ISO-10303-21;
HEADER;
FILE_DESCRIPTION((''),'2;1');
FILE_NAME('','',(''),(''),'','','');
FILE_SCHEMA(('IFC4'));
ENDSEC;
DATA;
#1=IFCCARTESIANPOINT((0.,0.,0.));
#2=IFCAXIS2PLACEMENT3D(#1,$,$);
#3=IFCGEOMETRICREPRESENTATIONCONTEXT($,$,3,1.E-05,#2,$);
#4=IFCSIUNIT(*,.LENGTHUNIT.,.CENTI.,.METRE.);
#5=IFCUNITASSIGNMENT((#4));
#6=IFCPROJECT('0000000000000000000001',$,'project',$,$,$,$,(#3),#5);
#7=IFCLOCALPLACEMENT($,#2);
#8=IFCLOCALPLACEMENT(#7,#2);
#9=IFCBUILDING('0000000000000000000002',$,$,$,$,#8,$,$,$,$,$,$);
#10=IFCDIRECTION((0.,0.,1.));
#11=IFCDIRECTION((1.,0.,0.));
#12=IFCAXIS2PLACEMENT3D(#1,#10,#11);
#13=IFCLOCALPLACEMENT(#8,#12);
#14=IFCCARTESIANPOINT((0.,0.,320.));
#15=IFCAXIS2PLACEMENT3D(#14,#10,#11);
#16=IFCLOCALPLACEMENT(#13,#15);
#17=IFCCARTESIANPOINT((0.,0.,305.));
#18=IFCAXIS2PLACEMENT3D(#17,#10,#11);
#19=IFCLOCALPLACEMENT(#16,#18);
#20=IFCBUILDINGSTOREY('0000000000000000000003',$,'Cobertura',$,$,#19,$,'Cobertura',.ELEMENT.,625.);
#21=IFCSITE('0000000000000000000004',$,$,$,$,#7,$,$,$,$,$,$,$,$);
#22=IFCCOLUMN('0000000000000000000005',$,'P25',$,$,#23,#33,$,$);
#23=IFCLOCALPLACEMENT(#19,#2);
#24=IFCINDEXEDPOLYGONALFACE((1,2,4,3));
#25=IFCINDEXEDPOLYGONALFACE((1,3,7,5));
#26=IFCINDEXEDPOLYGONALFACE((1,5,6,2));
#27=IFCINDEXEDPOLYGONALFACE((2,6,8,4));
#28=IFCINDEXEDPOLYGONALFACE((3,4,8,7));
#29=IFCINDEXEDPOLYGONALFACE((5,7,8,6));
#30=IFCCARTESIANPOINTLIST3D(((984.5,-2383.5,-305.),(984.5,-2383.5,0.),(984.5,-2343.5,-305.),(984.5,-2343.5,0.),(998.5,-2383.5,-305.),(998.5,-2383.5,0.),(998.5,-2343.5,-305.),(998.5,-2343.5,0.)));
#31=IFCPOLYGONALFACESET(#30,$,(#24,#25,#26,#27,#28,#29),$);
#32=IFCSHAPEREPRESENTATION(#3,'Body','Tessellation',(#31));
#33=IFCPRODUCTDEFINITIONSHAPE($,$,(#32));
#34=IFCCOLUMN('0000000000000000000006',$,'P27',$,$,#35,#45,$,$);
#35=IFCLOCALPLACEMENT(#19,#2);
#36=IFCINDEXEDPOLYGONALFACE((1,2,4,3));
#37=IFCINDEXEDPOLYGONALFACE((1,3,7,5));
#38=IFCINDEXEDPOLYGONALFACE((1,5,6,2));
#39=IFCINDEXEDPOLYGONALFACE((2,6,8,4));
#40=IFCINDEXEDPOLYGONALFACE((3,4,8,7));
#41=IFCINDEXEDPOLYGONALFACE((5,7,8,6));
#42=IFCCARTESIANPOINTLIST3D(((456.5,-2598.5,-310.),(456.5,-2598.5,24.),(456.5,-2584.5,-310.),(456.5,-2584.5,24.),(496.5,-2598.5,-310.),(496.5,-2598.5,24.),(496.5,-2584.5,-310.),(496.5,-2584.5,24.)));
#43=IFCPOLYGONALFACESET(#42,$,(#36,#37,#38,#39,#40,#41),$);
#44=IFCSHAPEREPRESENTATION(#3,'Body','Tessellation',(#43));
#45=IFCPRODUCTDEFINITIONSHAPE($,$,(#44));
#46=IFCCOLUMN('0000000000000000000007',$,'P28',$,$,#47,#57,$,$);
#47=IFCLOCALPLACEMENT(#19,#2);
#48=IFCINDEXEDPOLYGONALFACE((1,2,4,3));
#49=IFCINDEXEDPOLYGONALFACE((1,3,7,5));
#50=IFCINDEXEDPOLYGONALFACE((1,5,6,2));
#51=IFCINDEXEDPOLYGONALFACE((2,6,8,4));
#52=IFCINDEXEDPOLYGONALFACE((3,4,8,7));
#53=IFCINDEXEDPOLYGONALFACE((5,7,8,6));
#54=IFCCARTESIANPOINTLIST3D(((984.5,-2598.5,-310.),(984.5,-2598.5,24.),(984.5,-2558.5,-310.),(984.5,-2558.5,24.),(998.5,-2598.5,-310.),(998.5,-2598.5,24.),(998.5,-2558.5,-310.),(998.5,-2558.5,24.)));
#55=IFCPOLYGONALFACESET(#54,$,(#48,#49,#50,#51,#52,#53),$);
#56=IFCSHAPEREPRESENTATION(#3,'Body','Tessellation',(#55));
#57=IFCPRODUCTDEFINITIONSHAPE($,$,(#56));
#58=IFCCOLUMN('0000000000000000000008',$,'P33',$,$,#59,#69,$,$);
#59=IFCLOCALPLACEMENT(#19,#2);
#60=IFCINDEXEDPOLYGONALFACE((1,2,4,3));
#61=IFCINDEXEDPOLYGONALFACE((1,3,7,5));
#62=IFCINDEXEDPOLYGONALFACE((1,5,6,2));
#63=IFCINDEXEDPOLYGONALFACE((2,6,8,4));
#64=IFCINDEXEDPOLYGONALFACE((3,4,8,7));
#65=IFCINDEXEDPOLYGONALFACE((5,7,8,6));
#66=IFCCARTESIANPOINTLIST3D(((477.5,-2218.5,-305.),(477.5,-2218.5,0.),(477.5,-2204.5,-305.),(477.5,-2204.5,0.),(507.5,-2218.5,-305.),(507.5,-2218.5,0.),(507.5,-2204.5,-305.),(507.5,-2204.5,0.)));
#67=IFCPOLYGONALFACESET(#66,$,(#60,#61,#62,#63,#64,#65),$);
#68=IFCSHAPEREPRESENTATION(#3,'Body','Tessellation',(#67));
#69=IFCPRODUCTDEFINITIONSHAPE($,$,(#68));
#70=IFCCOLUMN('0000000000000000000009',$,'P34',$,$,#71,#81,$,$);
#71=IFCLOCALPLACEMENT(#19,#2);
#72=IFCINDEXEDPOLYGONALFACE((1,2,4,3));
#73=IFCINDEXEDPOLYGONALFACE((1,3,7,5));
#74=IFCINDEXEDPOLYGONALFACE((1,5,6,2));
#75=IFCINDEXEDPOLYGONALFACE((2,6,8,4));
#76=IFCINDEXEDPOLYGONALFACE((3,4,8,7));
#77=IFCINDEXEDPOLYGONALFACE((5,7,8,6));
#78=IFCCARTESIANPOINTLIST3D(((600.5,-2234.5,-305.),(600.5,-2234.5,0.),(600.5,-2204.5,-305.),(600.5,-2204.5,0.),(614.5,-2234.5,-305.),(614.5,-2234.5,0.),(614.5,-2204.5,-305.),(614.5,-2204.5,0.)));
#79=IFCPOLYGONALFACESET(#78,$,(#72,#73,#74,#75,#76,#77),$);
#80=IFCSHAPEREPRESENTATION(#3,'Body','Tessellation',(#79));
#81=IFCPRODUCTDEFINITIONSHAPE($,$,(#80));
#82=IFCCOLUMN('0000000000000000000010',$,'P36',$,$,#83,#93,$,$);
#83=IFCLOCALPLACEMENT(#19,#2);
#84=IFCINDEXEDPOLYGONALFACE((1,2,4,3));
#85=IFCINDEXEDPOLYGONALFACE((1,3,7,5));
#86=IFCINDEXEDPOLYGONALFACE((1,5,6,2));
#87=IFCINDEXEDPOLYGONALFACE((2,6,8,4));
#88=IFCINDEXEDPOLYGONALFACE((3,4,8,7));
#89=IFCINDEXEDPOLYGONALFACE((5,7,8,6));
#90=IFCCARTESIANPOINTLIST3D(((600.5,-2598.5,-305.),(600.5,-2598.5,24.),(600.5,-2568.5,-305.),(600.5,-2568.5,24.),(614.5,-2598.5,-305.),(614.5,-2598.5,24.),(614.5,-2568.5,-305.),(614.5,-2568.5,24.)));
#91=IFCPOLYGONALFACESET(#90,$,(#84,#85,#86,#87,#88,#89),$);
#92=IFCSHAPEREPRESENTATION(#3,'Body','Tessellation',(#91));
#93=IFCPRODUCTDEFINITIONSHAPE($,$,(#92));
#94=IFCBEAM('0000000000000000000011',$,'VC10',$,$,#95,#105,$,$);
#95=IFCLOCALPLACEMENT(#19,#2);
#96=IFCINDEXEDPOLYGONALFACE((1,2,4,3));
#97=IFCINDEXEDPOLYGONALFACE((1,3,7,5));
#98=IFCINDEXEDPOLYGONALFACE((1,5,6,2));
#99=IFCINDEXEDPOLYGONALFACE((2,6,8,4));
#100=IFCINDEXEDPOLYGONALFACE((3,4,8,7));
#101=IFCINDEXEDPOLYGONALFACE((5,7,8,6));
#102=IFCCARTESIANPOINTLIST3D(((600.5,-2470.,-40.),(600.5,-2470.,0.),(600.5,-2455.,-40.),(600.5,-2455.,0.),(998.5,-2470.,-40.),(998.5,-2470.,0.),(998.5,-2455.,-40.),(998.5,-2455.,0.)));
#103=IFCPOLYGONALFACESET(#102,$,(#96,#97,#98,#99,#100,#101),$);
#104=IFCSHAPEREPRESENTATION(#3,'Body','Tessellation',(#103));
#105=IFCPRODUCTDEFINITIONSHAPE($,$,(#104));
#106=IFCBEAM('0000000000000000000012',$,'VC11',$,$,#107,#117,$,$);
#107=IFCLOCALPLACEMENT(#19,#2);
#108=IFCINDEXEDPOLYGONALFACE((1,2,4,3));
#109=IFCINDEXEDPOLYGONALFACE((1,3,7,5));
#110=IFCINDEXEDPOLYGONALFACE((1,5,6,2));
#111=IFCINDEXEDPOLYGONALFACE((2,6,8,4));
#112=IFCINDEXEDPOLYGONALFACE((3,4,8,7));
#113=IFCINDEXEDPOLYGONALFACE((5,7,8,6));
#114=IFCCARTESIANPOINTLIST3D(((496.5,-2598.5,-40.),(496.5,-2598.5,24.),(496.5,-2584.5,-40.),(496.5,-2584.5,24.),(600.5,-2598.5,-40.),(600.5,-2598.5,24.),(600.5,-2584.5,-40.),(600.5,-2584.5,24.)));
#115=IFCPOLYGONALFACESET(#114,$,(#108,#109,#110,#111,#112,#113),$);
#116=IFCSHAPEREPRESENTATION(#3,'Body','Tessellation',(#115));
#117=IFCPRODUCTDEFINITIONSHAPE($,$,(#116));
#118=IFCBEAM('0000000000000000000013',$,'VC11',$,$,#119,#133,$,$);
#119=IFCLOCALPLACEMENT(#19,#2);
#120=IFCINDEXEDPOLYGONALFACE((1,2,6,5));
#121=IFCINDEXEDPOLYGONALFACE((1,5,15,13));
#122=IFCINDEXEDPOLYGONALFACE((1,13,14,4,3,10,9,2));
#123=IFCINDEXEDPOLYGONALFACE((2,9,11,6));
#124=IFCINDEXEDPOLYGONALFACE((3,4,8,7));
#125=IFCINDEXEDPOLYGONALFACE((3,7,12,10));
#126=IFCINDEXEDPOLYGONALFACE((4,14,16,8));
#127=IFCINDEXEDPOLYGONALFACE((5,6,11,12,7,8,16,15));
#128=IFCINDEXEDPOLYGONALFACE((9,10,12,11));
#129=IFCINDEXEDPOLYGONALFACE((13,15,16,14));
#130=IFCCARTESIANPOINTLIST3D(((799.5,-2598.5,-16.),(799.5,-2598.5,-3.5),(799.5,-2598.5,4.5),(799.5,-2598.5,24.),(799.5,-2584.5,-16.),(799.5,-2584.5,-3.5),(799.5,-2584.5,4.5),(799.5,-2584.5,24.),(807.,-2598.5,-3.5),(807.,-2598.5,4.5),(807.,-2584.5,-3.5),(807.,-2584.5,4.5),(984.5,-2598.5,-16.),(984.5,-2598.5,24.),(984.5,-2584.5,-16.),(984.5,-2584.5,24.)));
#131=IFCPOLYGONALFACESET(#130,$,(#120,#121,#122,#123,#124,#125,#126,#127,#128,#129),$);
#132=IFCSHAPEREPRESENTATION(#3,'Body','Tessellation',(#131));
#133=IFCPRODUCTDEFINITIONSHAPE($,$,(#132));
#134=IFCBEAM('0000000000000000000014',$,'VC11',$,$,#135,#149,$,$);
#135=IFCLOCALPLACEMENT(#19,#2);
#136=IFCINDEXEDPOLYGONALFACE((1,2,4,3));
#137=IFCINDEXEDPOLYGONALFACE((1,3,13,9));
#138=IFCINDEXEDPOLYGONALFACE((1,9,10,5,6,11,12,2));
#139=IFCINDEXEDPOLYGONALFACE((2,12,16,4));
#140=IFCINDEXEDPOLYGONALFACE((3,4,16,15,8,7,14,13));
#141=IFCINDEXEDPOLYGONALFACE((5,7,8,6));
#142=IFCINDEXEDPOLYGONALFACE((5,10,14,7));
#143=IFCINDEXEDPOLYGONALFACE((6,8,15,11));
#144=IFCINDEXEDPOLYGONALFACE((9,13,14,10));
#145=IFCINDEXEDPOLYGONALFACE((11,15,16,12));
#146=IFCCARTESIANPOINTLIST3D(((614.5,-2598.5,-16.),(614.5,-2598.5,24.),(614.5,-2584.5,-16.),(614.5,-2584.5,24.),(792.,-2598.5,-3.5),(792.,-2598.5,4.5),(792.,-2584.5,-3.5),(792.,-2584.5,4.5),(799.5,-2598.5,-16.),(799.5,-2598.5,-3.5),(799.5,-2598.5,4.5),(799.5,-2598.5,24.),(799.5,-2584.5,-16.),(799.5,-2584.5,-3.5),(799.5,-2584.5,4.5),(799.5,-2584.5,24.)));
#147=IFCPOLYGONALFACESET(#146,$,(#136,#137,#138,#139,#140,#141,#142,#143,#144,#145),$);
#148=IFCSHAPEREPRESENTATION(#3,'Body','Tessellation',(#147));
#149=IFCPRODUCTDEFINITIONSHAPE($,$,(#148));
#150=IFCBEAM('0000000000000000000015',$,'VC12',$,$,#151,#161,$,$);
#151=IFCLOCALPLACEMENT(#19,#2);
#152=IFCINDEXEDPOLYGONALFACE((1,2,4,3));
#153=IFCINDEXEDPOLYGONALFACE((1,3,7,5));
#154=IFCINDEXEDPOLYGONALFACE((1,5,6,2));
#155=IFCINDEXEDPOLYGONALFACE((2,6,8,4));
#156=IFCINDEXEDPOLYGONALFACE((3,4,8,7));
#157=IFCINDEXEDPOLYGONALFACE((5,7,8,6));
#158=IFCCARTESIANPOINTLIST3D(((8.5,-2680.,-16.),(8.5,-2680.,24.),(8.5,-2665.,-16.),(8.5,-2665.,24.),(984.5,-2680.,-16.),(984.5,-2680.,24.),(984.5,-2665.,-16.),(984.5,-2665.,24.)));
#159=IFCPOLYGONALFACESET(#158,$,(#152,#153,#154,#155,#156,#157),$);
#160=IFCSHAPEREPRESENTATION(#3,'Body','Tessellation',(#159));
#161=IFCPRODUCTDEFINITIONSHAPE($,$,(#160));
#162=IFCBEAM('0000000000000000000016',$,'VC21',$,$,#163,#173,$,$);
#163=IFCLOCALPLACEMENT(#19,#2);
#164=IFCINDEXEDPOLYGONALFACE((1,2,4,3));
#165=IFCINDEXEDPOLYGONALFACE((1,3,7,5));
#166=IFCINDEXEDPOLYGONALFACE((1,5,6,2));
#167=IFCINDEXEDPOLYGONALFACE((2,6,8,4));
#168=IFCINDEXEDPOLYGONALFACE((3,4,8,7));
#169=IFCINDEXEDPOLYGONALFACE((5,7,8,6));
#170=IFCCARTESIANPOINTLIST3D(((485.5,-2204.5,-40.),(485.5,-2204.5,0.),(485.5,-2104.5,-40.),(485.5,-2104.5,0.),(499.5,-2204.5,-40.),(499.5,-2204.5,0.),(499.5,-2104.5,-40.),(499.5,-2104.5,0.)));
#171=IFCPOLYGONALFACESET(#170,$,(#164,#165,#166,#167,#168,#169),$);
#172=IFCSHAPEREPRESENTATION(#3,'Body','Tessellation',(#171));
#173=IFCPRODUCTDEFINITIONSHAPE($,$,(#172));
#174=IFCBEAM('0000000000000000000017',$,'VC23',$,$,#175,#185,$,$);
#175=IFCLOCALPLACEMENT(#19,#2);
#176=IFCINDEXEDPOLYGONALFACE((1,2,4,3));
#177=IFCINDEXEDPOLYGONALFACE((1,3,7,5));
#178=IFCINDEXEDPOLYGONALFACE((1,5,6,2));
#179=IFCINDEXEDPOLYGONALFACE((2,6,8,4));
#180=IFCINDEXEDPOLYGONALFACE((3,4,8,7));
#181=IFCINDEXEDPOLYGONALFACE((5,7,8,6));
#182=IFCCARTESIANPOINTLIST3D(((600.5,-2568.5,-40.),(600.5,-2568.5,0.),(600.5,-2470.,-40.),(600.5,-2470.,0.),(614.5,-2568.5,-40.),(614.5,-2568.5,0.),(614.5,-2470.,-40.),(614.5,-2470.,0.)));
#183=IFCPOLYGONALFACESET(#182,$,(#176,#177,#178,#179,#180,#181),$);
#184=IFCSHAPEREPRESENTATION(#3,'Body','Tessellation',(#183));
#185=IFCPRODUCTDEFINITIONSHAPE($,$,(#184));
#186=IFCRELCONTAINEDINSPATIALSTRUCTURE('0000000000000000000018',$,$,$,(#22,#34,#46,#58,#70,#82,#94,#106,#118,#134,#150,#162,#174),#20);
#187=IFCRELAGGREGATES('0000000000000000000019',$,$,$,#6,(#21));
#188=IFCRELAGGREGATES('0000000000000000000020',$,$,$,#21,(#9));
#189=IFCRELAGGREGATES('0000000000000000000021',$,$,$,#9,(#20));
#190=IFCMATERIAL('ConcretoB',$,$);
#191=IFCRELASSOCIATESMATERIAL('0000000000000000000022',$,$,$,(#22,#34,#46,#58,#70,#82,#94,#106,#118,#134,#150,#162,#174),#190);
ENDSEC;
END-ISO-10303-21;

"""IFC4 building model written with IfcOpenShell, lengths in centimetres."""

from ifc_helpers import new_model, si_unit, frame, origin, origin_with_axes, place, context, project, spatial, polyline, outline, extrude, material, element, save


model = new_model("IFC4")

# Units and contexts
context_of_model = context(None, 3, precision=1e-05, world=origin())
ifc_project = project(units=[si_unit("LENGTHUNIT", "METRE", prefix="CENTI")], contexts=[context_of_model])

# Site, building, storey
site_placement = place(None, origin())
site = spatial("IfcSite", under=ifc_project, at=site_placement)
building_placement = place(site_placement, origin())
building = spatial("IfcBuilding", under=site, at=building_placement)
placement_1 = place(building_placement, origin_with_axes())
placement_2 = place(placement_1, frame((0.0, 0.0, 320.0), z_axis=(0.0, 0.0, 1.0), x_axis=(1.0, 0.0, 0.0)))
storey_placement = place(placement_2, frame((0.0, 0.0, 305.0), z_axis=(0.0, 0.0, 1.0), x_axis=(1.0, 0.0, 0.0)))
storey = spatial("IfcBuildingStorey", under=building, at=storey_placement, Name="Cobertura", LongName="Cobertura", CompositionType="ELEMENT", Elevation=625.0)

# Columns
ifc_material = material(Name="ConcretoB")
column_1_placement = place(storey_placement, frame((991.5, -2363.5, 0.0), z_axis=(0.0, 0.0, 1.0), x_axis=(1.0, 0.0, 0.0)))
element("IfcColumn", 1, at=column_1_placement, inside=storey, material=ifc_material, Name="P25", context=context_of_model, shape_type="SolidModel", body=[
    extrude(outline(polyline([(7.0, 20.0), (-7.0, 20.0), (-7.0, -20.0), (7.0, -20.0), (7.0, 20.0)])), origin_with_axes(), (0.0, 0.0, -1.0), 305.0),
])
column_2_placement = place(storey_placement, frame((476.5, -2591.5, 24.0), z_axis=(0.0, 0.0, 1.0), x_axis=(1.0, 0.0, 0.0)))
element("IfcColumn", 2, at=column_2_placement, inside=storey, material=ifc_material, Name="P27", context=context_of_model, shape_type="SolidModel", body=[
    extrude(outline(polyline([(20.0, -7.0), (20.0, 7.0), (-20.0, 7.0), (-20.0, -7.0), (20.0, -7.0)])), origin_with_axes(), (0.0, 0.0, -1.0), 334.0),
])
column_3_placement = place(storey_placement, frame((991.5, -2578.5, 24.0), z_axis=(0.0, 0.0, 1.0), x_axis=(1.0, 0.0, 0.0)))
element("IfcColumn", 3, at=column_3_placement, inside=storey, material=ifc_material, Name="P28", context=context_of_model, shape_type="SolidModel", body=[
    extrude(outline(polyline([(7.0, 20.0), (-7.0, 20.0), (-7.0, -20.0), (7.0, -20.0), (7.0, 20.0)])), origin_with_axes(), (0.0, 0.0, -1.0), 334.0),
])
column_4_placement = place(storey_placement, frame((492.5, -2211.5, 0.0), z_axis=(0.0, 0.0, 1.0), x_axis=(1.0, 0.0, 0.0)))
element("IfcColumn", 4, at=column_4_placement, inside=storey, material=ifc_material, Name="P33", context=context_of_model, shape_type="SolidModel", body=[
    extrude(outline(polyline([(15.0, -7.0), (15.0, 7.0), (-15.0, 7.0), (-15.0, -7.0), (15.0, -7.0)])), origin_with_axes(), (0.0, 0.0, -1.0), 305.0),
])
column_5_placement = place(storey_placement, frame((607.5, -2219.5, 0.0), z_axis=(0.0, 0.0, 1.0), x_axis=(1.0, 0.0, 0.0)))
element("IfcColumn", 5, at=column_5_placement, inside=storey, material=ifc_material, Name="P34", context=context_of_model, shape_type="SolidModel", body=[
    extrude(outline(polyline([(7.0, 15.0), (-7.0, 15.0), (-7.0, -15.0), (7.0, -15.0), (7.0, 15.0)])), origin_with_axes(), (0.0, 0.0, -1.0), 305.0),
])
column_6_placement = place(storey_placement, frame((607.5, -2583.5, 24.0), z_axis=(0.0, 0.0, 1.0), x_axis=(1.0, 0.0, 0.0)))
element("IfcColumn", 6, at=column_6_placement, inside=storey, material=ifc_material, Name="P36", context=context_of_model, shape_type="SolidModel", body=[
    extrude(outline(polyline([(7.0, 15.0), (-7.0, 15.0), (-7.0, -15.0), (7.0, -15.0), (7.0, 15.0)])), origin_with_axes(), (0.0, 0.0, -1.0), 329.0),
])

# Beams
beam_1_placement = place(storey_placement, frame((799.5, -2462.5, 0.0), z_axis=(0.0, 0.0, 1.0), x_axis=(1.0, 0.0, 0.0)))
element("IfcBeam", 7, at=beam_1_placement, inside=storey, material=ifc_material, Name="VC10", context=context_of_model, shape_type="SolidModel", body=[
    extrude(outline(polyline([(-7.5, -20.0), (7.5, -20.0), (7.5, 20.0), (-7.5, 20.0), (-7.5, -20.0)])), frame((-199.0, 0.0, -20.0), z_axis=(1.0, 0.0, 0.0), x_axis=(0.0, -1.0, 0.0)), (0.0, 0.0, 1.0), 398.0),
])
beam_2_placement = place(storey_placement, frame((548.5, -2591.5, 24.0), z_axis=(0.0, 0.0, 1.0), x_axis=(1.0, 0.0, 0.0)))
element("IfcBeam", 8, at=beam_2_placement, inside=storey, material=ifc_material, Name="VC11", context=context_of_model, shape_type="SolidModel", body=[
    extrude(outline(polyline([(-7.0, -32.0), (7.0, -32.0), (7.0, 32.0), (-7.0, 32.0), (-7.0, -32.0)])), frame((-52.0, 0.0, -32.0), z_axis=(1.0, 0.0, 0.0), x_axis=(0.0, -1.0, 0.0)), (0.0, 0.0, 1.0), 104.0),
])

# Beams, openings
beam_3_placement = place(storey_placement, frame((892.0, -2591.5, 24.0), z_axis=(0.0, 0.0, 1.0), x_axis=(1.0, 0.0, 0.0)))
beam_3 = element("IfcBeam", 9, at=beam_3_placement, inside=storey, material=ifc_material, Name="VC11", context=context_of_model, shape_type="SolidModel", body=[
    extrude(outline(polyline([(-7.0, -20.0), (7.0, -20.0), (7.0, 20.0), (-7.0, 20.0), (-7.0, -20.0)])), frame((-92.5, 0.0, -20.0), z_axis=(1.0, 0.0, 0.0), x_axis=(0.0, -1.0, 0.0)), (0.0, 0.0, 1.0), 185.0),
])
opening_1_placement = place(storey_placement, frame((0.0, 0.0, -625.0), z_axis=(0.0, 0.0, 1.0), x_axis=(1.0, 0.0, 0.0)))
element("IfcOpeningElement", 10, at=opening_1_placement, cuts=beam_3, material=ifc_material, context=context_of_model, shape_type="SweptSolid", body=[
    extrude(outline(polyline([(7.5, 4.0), (-7.5, 4.0), (-7.5, -4.0), (7.5, -4.0), (7.5, 4.0)])), frame((799.5, -2598.5, 625.5), z_axis=(0.0, 1.0, 0.0), x_axis=(-1.0, 0.0, 0.0)), (0.0, 0.0, 1.0), 14.0),
])
beam_4_placement = place(storey_placement, frame((707.0, -2591.5, 24.0), z_axis=(0.0, 0.0, 1.0), x_axis=(1.0, 0.0, 0.0)))
beam_4 = element("IfcBeam", 11, at=beam_4_placement, inside=storey, material=ifc_material, Name="VC11", context=context_of_model, shape_type="SolidModel", body=[
    extrude(outline(polyline([(-7.0, -20.0), (7.0, -20.0), (7.0, 20.0), (-7.0, 20.0), (-7.0, -20.0)])), frame((-92.5, 0.0, -20.0), z_axis=(1.0, 0.0, 0.0), x_axis=(0.0, -1.0, 0.0)), (0.0, 0.0, 1.0), 185.0),
])
opening_2_placement = place(storey_placement, frame((0.0, 0.0, -625.0), z_axis=(0.0, 0.0, 1.0), x_axis=(1.0, 0.0, 0.0)))
element("IfcOpeningElement", 12, at=opening_2_placement, cuts=beam_4, material=ifc_material, context=context_of_model, shape_type="SweptSolid", body=[
    extrude(outline(polyline([(7.5, 4.0), (-7.5, 4.0), (-7.5, -4.0), (7.5, -4.0), (7.5, 4.0)])), frame((799.5, -2598.5, 625.5), z_axis=(0.0, 1.0, 0.0), x_axis=(-1.0, 0.0, 0.0)), (0.0, 0.0, 1.0), 14.0),
])

# Beams
beam_5_placement = place(storey_placement, frame((496.5, -2672.5, 24.0), z_axis=(0.0, 0.0, 1.0), x_axis=(1.0, 0.0, 0.0)))
element("IfcBeam", 13, at=beam_5_placement, inside=storey, material=ifc_material, Name="VC12", context=context_of_model, shape_type="SolidModel", body=[
    extrude(outline(polyline([(-7.5, -20.0), (7.5, -20.0), (7.5, 20.0), (-7.5, 20.0), (-7.5, -20.0)])), frame((-488.0, 0.0, -20.0), z_axis=(1.0, 0.0, 0.0), x_axis=(0.0, -1.0, 0.0)), (0.0, 0.0, 1.0), 976.0),
])
beam_6_placement = place(storey_placement, frame((492.5, -2154.5, 0.0), z_axis=(0.0, 0.0, 1.0), x_axis=(1.0, 0.0, 0.0)))
element("IfcBeam", 14, at=beam_6_placement, inside=storey, material=ifc_material, Name="VC21", context=context_of_model, shape_type="SolidModel", body=[
    extrude(outline(polyline([(-7.0, -20.0), (7.0, -20.0), (7.0, 20.0), (-7.0, 20.0), (-7.0, -20.0)])), frame((0.0, -50.0, -20.0), z_axis=(0.0, 1.0, 0.0), x_axis=(1.0, 0.0, 0.0)), (0.0, 0.0, 1.0), 100.0),
])
beam_7_placement = place(storey_placement, frame((607.5, -2519.25, 0.0), z_axis=(0.0, 0.0, 1.0), x_axis=(1.0, 0.0, 0.0)))
element("IfcBeam", 15, at=beam_7_placement, inside=storey, material=ifc_material, Name="VC23", context=context_of_model, shape_type="SolidModel", body=[
    extrude(outline(polyline([(-7.0, -20.0), (7.0, -20.0), (7.0, 20.0), (-7.0, 20.0), (-7.0, -20.0)])), frame((0.0, -49.25, -20.0), z_axis=(0.0, 1.0, 0.0), x_axis=(1.0, 0.0, 0.0)), (0.0, 0.0, 1.0), 98.5),
])

save(model, "model.ifc")
